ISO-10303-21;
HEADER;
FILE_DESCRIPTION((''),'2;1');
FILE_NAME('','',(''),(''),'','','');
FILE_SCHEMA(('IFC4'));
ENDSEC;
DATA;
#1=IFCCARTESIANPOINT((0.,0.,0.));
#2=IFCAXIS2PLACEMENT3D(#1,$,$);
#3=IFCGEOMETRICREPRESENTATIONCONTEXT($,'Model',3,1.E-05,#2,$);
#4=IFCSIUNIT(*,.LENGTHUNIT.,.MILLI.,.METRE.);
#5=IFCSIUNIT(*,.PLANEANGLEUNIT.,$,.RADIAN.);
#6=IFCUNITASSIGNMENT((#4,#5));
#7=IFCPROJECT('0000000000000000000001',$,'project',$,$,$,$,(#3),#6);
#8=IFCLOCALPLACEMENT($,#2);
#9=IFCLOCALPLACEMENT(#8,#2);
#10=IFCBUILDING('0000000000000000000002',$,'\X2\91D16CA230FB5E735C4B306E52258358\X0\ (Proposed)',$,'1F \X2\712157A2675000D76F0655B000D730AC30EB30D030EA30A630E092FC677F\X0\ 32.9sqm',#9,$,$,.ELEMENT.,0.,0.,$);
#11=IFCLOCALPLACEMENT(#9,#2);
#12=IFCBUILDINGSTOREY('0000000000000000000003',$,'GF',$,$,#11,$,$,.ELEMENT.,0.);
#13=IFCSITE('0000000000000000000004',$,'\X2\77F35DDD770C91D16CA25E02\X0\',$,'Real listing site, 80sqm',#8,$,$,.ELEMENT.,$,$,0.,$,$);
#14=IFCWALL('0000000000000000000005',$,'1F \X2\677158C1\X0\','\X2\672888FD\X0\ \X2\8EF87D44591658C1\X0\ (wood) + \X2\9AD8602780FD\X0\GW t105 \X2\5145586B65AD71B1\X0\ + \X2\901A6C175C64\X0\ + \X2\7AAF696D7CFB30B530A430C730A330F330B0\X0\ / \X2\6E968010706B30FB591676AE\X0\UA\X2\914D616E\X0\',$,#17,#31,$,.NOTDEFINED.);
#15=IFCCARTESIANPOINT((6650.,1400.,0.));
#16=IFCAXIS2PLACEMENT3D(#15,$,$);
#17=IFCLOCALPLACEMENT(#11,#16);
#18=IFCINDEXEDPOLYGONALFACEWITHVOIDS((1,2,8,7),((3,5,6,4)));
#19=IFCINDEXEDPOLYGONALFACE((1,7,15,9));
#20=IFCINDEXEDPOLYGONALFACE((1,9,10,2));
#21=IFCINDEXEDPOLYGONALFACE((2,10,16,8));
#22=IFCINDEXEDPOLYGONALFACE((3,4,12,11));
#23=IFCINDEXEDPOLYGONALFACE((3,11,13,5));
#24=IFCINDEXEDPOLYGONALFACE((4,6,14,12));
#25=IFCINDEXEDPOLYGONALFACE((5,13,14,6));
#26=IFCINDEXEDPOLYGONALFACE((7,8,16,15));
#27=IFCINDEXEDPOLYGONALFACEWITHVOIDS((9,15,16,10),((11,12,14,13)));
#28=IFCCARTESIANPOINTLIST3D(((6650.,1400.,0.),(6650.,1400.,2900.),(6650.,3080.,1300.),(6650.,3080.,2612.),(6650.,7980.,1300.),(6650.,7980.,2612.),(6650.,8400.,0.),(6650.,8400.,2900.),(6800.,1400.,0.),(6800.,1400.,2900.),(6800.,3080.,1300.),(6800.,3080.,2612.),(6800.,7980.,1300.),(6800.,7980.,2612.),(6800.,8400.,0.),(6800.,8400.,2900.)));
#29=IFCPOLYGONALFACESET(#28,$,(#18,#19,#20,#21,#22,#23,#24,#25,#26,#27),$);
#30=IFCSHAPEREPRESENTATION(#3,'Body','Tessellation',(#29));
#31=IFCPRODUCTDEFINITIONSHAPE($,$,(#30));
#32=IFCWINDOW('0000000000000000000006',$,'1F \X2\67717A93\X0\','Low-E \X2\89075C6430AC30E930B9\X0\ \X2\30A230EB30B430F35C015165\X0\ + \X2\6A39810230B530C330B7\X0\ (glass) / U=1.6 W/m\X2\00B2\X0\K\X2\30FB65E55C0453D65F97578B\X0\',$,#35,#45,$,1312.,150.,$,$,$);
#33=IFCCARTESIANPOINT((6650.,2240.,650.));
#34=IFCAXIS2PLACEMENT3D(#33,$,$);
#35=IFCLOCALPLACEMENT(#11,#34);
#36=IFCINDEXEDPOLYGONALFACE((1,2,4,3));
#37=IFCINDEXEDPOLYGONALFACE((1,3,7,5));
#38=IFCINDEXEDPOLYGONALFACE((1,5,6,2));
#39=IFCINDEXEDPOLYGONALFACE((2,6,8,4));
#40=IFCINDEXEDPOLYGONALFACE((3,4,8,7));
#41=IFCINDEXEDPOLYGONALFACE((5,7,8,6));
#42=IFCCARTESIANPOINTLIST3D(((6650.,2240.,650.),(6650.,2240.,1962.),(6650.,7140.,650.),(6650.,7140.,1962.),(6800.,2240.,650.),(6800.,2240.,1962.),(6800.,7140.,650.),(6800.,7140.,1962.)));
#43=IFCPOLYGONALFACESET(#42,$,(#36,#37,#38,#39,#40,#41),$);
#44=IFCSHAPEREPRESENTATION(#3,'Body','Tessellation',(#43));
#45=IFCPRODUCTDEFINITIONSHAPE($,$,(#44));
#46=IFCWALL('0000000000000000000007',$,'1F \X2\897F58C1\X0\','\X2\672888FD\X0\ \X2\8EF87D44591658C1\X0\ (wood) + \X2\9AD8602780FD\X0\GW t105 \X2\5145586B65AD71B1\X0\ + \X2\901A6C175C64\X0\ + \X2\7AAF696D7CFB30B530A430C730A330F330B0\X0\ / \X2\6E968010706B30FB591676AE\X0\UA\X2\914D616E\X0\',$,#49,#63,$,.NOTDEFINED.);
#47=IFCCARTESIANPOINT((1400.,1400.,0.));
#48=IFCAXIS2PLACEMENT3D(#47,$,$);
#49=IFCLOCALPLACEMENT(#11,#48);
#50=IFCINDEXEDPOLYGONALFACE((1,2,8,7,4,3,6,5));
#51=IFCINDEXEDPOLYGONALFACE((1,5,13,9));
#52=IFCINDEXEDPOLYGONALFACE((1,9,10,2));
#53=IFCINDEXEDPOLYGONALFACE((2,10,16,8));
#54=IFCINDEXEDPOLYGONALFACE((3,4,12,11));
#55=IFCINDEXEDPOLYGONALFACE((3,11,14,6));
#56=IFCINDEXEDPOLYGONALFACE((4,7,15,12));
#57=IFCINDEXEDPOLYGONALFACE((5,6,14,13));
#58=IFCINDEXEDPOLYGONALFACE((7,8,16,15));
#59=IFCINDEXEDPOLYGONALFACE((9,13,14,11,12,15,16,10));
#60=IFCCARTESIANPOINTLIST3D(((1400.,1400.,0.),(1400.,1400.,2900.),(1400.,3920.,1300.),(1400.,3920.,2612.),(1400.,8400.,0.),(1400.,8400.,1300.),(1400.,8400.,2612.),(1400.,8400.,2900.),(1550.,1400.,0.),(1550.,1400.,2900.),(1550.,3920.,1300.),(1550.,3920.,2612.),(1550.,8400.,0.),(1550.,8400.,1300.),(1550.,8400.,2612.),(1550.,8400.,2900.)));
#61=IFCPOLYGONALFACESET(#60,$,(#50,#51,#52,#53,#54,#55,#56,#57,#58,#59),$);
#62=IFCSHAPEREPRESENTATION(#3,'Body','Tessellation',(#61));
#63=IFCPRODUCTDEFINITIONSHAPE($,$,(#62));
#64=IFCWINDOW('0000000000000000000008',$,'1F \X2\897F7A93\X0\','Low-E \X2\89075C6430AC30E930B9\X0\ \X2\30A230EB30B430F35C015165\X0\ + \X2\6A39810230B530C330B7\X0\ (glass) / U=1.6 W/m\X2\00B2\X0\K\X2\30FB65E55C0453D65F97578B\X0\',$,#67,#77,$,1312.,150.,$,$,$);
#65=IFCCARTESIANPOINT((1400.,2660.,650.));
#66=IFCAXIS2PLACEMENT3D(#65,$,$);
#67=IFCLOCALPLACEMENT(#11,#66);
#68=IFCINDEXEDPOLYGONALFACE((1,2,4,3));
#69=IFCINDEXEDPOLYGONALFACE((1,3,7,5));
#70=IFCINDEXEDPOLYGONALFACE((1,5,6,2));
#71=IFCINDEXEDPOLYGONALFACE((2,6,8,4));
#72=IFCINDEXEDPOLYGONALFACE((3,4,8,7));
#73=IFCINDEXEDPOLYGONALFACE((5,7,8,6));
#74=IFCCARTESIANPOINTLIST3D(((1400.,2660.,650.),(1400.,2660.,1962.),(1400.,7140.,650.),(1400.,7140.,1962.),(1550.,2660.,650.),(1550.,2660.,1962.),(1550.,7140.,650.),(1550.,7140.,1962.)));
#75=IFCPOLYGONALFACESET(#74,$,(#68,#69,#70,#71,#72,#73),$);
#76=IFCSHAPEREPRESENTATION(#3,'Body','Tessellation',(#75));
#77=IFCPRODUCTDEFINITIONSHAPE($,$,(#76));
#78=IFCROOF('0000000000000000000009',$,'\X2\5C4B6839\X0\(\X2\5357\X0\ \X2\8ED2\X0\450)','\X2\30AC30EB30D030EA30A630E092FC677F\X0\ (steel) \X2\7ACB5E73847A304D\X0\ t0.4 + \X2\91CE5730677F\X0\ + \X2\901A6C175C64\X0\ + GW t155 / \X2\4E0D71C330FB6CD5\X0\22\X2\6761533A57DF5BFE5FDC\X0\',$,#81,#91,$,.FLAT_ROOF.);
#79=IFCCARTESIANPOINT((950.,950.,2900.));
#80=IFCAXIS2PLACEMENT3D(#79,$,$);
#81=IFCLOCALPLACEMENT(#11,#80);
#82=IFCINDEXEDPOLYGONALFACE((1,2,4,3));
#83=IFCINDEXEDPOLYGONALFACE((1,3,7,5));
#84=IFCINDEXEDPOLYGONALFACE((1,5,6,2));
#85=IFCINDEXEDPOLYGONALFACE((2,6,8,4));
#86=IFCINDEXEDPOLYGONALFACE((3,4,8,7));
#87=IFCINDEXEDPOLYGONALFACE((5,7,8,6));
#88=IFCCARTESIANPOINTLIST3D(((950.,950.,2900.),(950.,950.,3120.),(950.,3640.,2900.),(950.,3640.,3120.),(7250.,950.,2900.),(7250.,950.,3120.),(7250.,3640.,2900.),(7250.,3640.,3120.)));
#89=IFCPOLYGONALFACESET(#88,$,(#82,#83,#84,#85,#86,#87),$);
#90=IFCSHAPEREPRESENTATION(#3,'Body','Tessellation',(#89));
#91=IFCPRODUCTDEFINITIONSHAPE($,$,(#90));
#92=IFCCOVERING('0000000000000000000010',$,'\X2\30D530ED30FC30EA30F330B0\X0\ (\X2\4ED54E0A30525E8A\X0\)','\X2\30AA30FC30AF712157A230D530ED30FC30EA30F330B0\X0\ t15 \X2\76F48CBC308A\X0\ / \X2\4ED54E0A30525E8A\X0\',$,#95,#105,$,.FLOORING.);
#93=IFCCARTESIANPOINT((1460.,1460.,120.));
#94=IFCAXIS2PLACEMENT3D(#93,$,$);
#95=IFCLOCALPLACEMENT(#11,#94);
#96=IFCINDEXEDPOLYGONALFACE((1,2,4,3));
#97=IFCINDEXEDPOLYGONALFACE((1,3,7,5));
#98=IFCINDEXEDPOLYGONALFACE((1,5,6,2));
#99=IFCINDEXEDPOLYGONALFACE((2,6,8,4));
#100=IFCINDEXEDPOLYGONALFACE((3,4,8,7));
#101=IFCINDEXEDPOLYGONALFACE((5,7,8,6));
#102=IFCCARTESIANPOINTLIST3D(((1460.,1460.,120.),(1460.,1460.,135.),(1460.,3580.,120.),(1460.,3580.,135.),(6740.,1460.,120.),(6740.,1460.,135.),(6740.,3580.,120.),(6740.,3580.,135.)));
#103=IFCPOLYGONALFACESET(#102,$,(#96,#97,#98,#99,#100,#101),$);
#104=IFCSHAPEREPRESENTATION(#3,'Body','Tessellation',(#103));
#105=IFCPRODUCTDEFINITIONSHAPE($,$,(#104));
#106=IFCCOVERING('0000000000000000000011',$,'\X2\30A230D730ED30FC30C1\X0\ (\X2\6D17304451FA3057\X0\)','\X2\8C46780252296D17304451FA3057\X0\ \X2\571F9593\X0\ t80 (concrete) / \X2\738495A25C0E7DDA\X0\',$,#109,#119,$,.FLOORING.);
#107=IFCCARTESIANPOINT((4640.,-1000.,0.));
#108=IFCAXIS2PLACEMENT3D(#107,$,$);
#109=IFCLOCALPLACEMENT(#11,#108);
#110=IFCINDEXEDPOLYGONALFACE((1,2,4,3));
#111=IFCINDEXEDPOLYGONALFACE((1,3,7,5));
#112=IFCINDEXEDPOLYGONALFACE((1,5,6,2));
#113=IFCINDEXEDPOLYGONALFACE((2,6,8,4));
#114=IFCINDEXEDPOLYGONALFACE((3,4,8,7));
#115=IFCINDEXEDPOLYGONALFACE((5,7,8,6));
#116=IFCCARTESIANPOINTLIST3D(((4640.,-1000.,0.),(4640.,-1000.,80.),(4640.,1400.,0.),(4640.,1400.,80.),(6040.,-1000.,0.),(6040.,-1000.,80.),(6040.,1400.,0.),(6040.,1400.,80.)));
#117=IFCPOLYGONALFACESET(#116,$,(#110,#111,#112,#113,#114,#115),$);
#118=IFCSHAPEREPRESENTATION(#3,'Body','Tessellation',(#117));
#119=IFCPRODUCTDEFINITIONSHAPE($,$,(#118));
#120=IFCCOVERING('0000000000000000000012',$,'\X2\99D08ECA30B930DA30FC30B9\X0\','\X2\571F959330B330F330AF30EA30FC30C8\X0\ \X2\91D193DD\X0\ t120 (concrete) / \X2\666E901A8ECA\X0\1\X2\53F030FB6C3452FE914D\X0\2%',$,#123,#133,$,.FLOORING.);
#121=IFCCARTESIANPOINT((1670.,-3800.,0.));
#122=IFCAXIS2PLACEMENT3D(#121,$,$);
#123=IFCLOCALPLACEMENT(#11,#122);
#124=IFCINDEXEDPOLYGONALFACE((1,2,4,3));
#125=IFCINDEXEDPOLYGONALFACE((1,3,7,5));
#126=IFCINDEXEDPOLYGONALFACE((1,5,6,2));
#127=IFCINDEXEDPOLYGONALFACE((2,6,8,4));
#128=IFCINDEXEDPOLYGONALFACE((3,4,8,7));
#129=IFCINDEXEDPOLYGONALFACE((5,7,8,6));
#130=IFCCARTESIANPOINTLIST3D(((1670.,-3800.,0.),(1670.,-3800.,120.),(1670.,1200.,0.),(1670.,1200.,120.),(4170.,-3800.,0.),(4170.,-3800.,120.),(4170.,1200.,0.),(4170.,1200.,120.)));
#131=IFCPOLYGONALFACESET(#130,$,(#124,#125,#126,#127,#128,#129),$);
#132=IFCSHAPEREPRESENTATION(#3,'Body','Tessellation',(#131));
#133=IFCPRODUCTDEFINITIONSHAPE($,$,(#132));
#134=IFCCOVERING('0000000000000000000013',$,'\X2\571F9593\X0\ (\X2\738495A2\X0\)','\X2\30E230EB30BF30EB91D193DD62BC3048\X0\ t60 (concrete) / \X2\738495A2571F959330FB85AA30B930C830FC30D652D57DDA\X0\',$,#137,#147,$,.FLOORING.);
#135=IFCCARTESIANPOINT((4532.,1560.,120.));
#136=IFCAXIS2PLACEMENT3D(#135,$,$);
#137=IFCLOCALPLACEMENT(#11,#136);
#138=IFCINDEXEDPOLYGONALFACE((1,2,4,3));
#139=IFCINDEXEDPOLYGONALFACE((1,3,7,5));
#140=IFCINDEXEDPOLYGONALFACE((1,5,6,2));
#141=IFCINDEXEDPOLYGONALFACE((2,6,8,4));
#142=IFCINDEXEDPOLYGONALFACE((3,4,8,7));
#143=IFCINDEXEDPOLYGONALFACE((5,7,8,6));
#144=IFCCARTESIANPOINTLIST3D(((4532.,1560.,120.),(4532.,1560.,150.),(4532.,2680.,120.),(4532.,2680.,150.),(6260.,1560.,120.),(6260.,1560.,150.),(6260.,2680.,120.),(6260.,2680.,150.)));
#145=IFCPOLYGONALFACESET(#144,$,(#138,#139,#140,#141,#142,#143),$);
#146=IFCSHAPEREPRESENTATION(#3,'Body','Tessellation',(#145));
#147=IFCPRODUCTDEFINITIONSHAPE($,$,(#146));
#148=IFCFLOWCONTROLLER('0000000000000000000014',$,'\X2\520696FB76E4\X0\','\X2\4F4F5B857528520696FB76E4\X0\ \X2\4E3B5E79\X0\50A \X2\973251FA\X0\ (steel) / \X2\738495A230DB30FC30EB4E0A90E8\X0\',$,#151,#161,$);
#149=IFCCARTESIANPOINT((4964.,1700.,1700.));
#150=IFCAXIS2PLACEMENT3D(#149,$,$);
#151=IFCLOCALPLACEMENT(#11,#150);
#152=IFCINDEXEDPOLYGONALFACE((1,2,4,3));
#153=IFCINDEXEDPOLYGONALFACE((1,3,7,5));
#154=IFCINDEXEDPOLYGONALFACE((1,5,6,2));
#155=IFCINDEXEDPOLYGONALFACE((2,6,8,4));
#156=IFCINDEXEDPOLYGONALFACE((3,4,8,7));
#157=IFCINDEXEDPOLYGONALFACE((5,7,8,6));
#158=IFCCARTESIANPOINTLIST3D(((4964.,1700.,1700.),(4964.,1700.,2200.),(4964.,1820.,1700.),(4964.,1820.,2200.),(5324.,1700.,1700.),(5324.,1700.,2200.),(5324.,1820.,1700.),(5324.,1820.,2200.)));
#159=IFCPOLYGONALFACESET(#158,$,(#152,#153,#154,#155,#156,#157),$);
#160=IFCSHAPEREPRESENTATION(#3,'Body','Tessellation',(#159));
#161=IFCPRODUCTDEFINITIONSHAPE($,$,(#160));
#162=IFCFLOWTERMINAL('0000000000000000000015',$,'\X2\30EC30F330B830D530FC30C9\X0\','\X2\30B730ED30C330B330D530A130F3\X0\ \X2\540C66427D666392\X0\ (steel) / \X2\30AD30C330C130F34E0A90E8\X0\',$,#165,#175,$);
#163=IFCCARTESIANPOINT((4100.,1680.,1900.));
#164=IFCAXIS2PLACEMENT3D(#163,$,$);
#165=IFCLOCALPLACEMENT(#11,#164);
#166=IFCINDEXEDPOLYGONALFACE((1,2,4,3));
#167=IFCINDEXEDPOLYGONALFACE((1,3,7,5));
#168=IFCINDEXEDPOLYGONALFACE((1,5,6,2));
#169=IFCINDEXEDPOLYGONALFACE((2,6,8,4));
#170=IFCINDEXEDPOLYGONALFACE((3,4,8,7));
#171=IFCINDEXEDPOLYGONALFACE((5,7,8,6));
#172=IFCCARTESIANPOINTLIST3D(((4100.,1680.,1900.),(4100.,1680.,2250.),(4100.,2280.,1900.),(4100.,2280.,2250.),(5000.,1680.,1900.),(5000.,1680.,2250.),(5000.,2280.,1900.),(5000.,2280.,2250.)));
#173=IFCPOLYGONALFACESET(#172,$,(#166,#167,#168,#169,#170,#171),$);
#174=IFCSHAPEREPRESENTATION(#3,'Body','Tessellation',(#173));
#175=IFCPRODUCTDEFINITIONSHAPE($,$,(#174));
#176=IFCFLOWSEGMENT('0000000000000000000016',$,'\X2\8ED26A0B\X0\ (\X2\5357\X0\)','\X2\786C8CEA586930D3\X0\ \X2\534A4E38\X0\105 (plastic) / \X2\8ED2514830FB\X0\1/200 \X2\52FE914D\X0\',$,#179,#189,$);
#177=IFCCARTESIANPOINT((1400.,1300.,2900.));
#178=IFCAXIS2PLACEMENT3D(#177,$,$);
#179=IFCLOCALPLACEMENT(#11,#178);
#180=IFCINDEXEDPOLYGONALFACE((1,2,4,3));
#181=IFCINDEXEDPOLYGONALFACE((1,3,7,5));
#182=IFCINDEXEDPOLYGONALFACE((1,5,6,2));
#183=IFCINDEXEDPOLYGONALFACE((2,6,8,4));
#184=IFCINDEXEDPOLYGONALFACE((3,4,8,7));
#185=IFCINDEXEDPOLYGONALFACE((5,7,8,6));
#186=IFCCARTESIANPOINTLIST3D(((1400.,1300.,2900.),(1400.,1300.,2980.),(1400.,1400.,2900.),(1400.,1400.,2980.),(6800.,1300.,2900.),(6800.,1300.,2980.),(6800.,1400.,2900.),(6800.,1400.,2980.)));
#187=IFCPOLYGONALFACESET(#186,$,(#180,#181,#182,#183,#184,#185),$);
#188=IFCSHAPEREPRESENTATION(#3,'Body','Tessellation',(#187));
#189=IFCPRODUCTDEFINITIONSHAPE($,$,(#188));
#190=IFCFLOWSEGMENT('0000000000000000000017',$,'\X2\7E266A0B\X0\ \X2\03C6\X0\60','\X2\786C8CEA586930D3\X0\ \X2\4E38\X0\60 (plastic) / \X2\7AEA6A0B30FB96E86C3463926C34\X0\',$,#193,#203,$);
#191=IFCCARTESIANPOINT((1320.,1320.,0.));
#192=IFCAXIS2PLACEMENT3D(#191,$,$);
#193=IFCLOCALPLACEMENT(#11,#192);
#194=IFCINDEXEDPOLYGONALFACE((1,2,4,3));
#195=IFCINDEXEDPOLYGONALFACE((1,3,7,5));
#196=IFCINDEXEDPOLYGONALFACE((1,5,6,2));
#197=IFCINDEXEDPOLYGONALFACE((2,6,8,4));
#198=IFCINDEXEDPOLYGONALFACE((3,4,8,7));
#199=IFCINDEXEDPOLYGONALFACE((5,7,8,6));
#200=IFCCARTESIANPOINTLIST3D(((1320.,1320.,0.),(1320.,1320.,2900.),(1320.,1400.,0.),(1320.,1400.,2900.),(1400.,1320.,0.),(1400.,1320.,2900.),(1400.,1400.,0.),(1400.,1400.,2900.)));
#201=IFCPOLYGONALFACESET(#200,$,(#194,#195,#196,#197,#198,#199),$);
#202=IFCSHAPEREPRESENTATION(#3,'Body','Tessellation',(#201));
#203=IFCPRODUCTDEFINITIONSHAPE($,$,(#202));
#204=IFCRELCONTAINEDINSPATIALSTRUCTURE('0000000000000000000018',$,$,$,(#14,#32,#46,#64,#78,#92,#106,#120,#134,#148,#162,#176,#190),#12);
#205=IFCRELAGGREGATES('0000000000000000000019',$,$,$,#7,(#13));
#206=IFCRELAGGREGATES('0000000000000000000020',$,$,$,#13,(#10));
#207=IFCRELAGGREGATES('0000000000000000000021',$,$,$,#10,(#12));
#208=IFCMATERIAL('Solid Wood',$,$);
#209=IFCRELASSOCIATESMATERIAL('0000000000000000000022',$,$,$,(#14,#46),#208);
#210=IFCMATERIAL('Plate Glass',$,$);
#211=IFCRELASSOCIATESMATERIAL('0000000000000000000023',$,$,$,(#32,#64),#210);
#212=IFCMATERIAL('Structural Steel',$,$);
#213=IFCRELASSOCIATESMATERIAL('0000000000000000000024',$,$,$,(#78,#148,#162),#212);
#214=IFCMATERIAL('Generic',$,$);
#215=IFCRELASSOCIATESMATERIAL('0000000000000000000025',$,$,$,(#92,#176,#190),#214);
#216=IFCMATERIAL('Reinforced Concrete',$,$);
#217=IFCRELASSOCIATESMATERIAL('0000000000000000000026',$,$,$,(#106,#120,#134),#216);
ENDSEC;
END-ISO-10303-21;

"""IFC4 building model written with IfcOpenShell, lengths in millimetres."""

from ifc_helpers import new_model, si_unit, frame, frame_2d, origin, place, context, project, spatial, rectangle, extrude, material, element, fill, save


model = new_model("IFC4")

# Units and contexts
model_context = context("Model", 3, precision=1e-05, world=origin())
ifc_project = project(units=[si_unit("LENGTHUNIT", "METRE", prefix="MILLI"), si_unit("PLANEANGLEUNIT", "RADIAN")], contexts=[model_context])

# Site, building, storey
site_placement = place(None, origin())
site = spatial("IfcSite", under=ifc_project, at=site_placement, Name="石川県金沢市", ObjectType="Real listing site, 80sqm", CompositionType="ELEMENT", RefElevation=0.0)
building_placement = place(site_placement, origin())
building = spatial("IfcBuilding", under=site, at=building_placement, Name="金沢・平屋の別荘 (Proposed)", ObjectType="1F 無垢材×漆喰×ガルバリウム鋼板 32.9sqm", CompositionType="ELEMENT", ElevationOfRefHeight=0.0, ElevationOfTerrain=0.0)
storey_placement = place(building_placement, origin())
storey = spatial("IfcBuildingStorey", under=building, at=storey_placement, Name="GF", CompositionType="ELEMENT", Elevation=0.0)

# Shared definitions
ifc_material_1 = material(Name="Solid Wood")

# Shared definitions
ifc_material_2 = material(Name="Reinforced Concrete")

# Shared definitions
ifc_material_3 = material(Name="Plate Glass")

# Walls, openings, windows
wall_1_placement = place(storey_placement, frame((6650.0, 1400.0, 0.0)))
wall_1 = element("IfcWall", 1, at=wall_1_placement, inside=storey, material=ifc_material_1, Name="1F 東壁", Description="木製 軸組外壁 (wood) + 高性能GW t105 充填断熱 + 通気層 + 窯業系サイディング / 準耐火・外皮UA配慮", PredefinedType="NOTDEFINED", context=model_context, shape_type="SweptSolid", body=[
    extrude(rectangle(XDim=150.0, YDim=7000.0, at=frame_2d((75.0, 3500.0))), frame((6650.0, 1400.0, 0.0)), (0.0, 0.0, 1.0), 2900.0),
])
opening_1_placement = place(storey_placement, frame((6650.0, 2240.0, 650.0)))
opening_1 = element("IfcOpeningElement", 2, at=opening_1_placement, cuts=wall_1, PredefinedType="NOTDEFINED", context=model_context, shape_type="SweptSolid", body=[
    extrude(rectangle(XDim=150.0, YDim=4900.0, at=frame_2d((75.0, 2450.0))), frame((6650.0, 2240.0, 650.0)), (0.0, 0.0, 1.0), 1312.0),
])
window_1_placement = place(storey_placement, frame((6650.0, 2240.0, 650.0)))
window_1 = element("IfcWindow", 3, at=window_1_placement, inside=storey, material=ifc_material_3, Name="1F 東窓", Description="Low-E 複層ガラス アルゴン封入 + 樹脂サッシ (glass) / U=1.6 W/m²K・日射取得型", OverallHeight=1312.0, OverallWidth=150.0, context=model_context, shape_type="SweptSolid", body=[
    extrude(rectangle(XDim=150.0, YDim=4900.0, at=frame_2d((75.0, 2450.0))), frame((6650.0, 2240.0, 650.0)), (0.0, 0.0, 1.0), 1312.0),
])
fill(opening_1, window_1)
wall_2_placement = place(storey_placement, frame((1400.0, 1400.0, 0.0)))
wall_2 = element("IfcWall", 4, at=wall_2_placement, inside=storey, material=ifc_material_1, Name="1F 西壁", Description="木製 軸組外壁 (wood) + 高性能GW t105 充填断熱 + 通気層 + 窯業系サイディング / 準耐火・外皮UA配慮", PredefinedType="NOTDEFINED", context=model_context, shape_type="SweptSolid", body=[
    extrude(rectangle(XDim=150.0, YDim=7000.0, at=frame_2d((75.0, 3500.0))), frame((1400.0, 1400.0, 0.0)), (0.0, 0.0, 1.0), 2900.0),
])
opening_2_placement = place(storey_placement, frame((1400.0, 2660.0, 650.0)))
opening_2 = element("IfcOpeningElement", 5, at=opening_2_placement, cuts=wall_2, PredefinedType="NOTDEFINED", context=model_context, shape_type="SweptSolid", body=[
    extrude(rectangle(XDim=150.0, YDim=4480.0, at=frame_2d((75.0, 2240.0))), frame((1400.0, 2660.0, 650.0)), (0.0, 0.0, 1.0), 1312.0),
])
window_2_placement = place(storey_placement, frame((1400.0, 2660.0, 650.0)))
window_2 = element("IfcWindow", 6, at=window_2_placement, inside=storey, material=ifc_material_3, Name="1F 西窓", Description="Low-E 複層ガラス アルゴン封入 + 樹脂サッシ (glass) / U=1.6 W/m²K・日射取得型", OverallHeight=1312.0, OverallWidth=150.0, context=model_context, shape_type="SweptSolid", body=[
    extrude(rectangle(XDim=150.0, YDim=4480.0, at=frame_2d((75.0, 2240.0))), frame((1400.0, 2660.0, 650.0)), (0.0, 0.0, 1.0), 1312.0),
])
fill(opening_2, window_2)

# Roof
ifc_material_4 = material(Name="Structural Steel")
roof_placement = place(storey_placement, frame((950.0, 950.0, 2900.0)))
element("IfcRoof", 7, at=roof_placement, inside=storey, material=ifc_material_4, Name="屋根(南 軒450)", Description="ガルバリウム鋼板 (steel) 立平葺き t0.4 + 野地板 + 通気層 + GW t155 / 不燃・法22条区域対応", PredefinedType="FLAT_ROOF", context=model_context, shape_type="SweptSolid", body=[
    extrude(rectangle(XDim=6300.0, YDim=2690.0, at=frame_2d((3150.0, 1345.0))), frame((950.0, 950.0, 2900.0)), (0.0, 0.0, 1.0), 220.0),
])

# Coverings
ifc_material_5 = material(Name="Generic")
covering_1_placement = place(storey_placement, frame((1460.0, 1460.0, 120.0)))
element("IfcCovering", 8, at=covering_1_placement, inside=storey, material=ifc_material_5, Name="フローリング (仕上げ床)", Description="オーク無垢フローリング t15 直貼り / 仕上げ床", PredefinedType="FLOORING", context=model_context, shape_type="SweptSolid", body=[
    extrude(rectangle(XDim=5280.0, YDim=2120.0, at=frame_2d((2640.0, 1060.0))), frame((1460.0, 1460.0, 120.0)), (0.0, 0.0, 1.0), 15.0),
])
covering_2_placement = place(storey_placement, frame((4640.0, -1000.0, 0.0)))
element("IfcCovering", 9, at=covering_2_placement, inside=storey, material=ifc_material_2, Name="アプローチ (洗い出し)", Description="豆砂利洗い出し 土間 t80 (concrete) / 玄関導線", PredefinedType="FLOORING", context=model_context, shape_type="SweptSolid", body=[
    extrude(rectangle(XDim=1400.0, YDim=2400.0, at=frame_2d((700.0, 1200.0))), frame((4640.0, -1000.0, 0.0)), (0.0, 0.0, 1.0), 80.0),
])
covering_3_placement = place(storey_placement, frame((1670.0, -3800.0, 0.0)))
element("IfcCovering", 10, at=covering_3_placement, inside=storey, material=ifc_material_2, Name="駐車スペース", Description="土間コンクリート 金鏝 t120 (concrete) / 普通車1台・水勾配2%", PredefinedType="FLOORING", context=model_context, shape_type="SweptSolid", body=[
    extrude(rectangle(XDim=2500.0, YDim=5000.0, at=frame_2d((1250.0, 2500.0))), frame((1670.0, -3800.0, 0.0)), (0.0, 0.0, 1.0), 120.0),
])
covering_4_placement = place(storey_placement, frame((4532.0, 1560.0, 120.0)))
element("IfcCovering", 11, at=covering_4_placement, inside=storey, material=ifc_material_2, Name="土間 (玄関)", Description="モルタル金鏝押え t60 (concrete) / 玄関土間・薪ストーブ動線", PredefinedType="FLOORING", context=model_context, shape_type="SweptSolid", body=[
    extrude(rectangle(XDim=1728.0, YDim=1120.0, at=frame_2d((864.0, 560.0))), frame((4532.0, 1560.0, 120.0)), (0.0, 0.0, 1.0), 30.0),
])

# Flow controller
flow_controller_placement = place(storey_placement, frame((4964.0, 1700.0, 1700.0)))
element("IfcFlowController", 12, at=flow_controller_placement, inside=storey, material=ifc_material_4, Name="分電盤", Description="住宅用分電盤 主幹50A 露出 (steel) / 玄関ホール上部", context=model_context, shape_type="SweptSolid", body=[
    extrude(rectangle(XDim=360.0, YDim=120.0, at=frame_2d((180.0, 60.0))), frame((4964.0, 1700.0, 1700.0)), (0.0, 0.0, 1.0), 500.0),
])

# Flow terminal
flow_terminal_placement = place(storey_placement, frame((4100.0, 1680.0, 1900.0)))
element("IfcFlowTerminal", 13, at=flow_terminal_placement, inside=storey, material=ifc_material_4, Name="レンジフード", Description="シロッコファン 同時給排 (steel) / キッチン上部", context=model_context, shape_type="SweptSolid", body=[
    extrude(rectangle(XDim=900.0, YDim=600.0, at=frame_2d((450.0, 300.0))), frame((4100.0, 1680.0, 1900.0)), (0.0, 0.0, 1.0), 350.0),
])

# Flow segments
flow_segment_1_placement = place(storey_placement, frame((1400.0, 1300.0, 2900.0)))
element("IfcFlowSegment", 14, at=flow_segment_1_placement, inside=storey, material=ifc_material_5, Name="軒樋 (南)", Description="硬質塩ビ 半丸105 (plastic) / 軒先・1/200 勾配", context=model_context, shape_type="SweptSolid", body=[
    extrude(rectangle(XDim=5400.0, YDim=100.0, at=frame_2d((2700.0, 50.0))), frame((1400.0, 1300.0, 2900.0)), (0.0, 0.0, 1.0), 80.0),
])
flow_segment_2_placement = place(storey_placement, frame((1320.0, 1320.0, 0.0)))
element("IfcFlowSegment", 15, at=flow_segment_2_placement, inside=storey, material=ifc_material_5, Name="縦樋 φ60", Description="硬質塩ビ 丸60 (plastic) / 竪樋・雨水排水", context=model_context, shape_type="SweptSolid", body=[
    extrude(rectangle(XDim=80.0, YDim=80.0, at=frame_2d((40.0, 40.0))), frame((1320.0, 1320.0, 0.0)), (0.0, 0.0, 1.0), 2900.0),
])

save(model, "model.ifc")
